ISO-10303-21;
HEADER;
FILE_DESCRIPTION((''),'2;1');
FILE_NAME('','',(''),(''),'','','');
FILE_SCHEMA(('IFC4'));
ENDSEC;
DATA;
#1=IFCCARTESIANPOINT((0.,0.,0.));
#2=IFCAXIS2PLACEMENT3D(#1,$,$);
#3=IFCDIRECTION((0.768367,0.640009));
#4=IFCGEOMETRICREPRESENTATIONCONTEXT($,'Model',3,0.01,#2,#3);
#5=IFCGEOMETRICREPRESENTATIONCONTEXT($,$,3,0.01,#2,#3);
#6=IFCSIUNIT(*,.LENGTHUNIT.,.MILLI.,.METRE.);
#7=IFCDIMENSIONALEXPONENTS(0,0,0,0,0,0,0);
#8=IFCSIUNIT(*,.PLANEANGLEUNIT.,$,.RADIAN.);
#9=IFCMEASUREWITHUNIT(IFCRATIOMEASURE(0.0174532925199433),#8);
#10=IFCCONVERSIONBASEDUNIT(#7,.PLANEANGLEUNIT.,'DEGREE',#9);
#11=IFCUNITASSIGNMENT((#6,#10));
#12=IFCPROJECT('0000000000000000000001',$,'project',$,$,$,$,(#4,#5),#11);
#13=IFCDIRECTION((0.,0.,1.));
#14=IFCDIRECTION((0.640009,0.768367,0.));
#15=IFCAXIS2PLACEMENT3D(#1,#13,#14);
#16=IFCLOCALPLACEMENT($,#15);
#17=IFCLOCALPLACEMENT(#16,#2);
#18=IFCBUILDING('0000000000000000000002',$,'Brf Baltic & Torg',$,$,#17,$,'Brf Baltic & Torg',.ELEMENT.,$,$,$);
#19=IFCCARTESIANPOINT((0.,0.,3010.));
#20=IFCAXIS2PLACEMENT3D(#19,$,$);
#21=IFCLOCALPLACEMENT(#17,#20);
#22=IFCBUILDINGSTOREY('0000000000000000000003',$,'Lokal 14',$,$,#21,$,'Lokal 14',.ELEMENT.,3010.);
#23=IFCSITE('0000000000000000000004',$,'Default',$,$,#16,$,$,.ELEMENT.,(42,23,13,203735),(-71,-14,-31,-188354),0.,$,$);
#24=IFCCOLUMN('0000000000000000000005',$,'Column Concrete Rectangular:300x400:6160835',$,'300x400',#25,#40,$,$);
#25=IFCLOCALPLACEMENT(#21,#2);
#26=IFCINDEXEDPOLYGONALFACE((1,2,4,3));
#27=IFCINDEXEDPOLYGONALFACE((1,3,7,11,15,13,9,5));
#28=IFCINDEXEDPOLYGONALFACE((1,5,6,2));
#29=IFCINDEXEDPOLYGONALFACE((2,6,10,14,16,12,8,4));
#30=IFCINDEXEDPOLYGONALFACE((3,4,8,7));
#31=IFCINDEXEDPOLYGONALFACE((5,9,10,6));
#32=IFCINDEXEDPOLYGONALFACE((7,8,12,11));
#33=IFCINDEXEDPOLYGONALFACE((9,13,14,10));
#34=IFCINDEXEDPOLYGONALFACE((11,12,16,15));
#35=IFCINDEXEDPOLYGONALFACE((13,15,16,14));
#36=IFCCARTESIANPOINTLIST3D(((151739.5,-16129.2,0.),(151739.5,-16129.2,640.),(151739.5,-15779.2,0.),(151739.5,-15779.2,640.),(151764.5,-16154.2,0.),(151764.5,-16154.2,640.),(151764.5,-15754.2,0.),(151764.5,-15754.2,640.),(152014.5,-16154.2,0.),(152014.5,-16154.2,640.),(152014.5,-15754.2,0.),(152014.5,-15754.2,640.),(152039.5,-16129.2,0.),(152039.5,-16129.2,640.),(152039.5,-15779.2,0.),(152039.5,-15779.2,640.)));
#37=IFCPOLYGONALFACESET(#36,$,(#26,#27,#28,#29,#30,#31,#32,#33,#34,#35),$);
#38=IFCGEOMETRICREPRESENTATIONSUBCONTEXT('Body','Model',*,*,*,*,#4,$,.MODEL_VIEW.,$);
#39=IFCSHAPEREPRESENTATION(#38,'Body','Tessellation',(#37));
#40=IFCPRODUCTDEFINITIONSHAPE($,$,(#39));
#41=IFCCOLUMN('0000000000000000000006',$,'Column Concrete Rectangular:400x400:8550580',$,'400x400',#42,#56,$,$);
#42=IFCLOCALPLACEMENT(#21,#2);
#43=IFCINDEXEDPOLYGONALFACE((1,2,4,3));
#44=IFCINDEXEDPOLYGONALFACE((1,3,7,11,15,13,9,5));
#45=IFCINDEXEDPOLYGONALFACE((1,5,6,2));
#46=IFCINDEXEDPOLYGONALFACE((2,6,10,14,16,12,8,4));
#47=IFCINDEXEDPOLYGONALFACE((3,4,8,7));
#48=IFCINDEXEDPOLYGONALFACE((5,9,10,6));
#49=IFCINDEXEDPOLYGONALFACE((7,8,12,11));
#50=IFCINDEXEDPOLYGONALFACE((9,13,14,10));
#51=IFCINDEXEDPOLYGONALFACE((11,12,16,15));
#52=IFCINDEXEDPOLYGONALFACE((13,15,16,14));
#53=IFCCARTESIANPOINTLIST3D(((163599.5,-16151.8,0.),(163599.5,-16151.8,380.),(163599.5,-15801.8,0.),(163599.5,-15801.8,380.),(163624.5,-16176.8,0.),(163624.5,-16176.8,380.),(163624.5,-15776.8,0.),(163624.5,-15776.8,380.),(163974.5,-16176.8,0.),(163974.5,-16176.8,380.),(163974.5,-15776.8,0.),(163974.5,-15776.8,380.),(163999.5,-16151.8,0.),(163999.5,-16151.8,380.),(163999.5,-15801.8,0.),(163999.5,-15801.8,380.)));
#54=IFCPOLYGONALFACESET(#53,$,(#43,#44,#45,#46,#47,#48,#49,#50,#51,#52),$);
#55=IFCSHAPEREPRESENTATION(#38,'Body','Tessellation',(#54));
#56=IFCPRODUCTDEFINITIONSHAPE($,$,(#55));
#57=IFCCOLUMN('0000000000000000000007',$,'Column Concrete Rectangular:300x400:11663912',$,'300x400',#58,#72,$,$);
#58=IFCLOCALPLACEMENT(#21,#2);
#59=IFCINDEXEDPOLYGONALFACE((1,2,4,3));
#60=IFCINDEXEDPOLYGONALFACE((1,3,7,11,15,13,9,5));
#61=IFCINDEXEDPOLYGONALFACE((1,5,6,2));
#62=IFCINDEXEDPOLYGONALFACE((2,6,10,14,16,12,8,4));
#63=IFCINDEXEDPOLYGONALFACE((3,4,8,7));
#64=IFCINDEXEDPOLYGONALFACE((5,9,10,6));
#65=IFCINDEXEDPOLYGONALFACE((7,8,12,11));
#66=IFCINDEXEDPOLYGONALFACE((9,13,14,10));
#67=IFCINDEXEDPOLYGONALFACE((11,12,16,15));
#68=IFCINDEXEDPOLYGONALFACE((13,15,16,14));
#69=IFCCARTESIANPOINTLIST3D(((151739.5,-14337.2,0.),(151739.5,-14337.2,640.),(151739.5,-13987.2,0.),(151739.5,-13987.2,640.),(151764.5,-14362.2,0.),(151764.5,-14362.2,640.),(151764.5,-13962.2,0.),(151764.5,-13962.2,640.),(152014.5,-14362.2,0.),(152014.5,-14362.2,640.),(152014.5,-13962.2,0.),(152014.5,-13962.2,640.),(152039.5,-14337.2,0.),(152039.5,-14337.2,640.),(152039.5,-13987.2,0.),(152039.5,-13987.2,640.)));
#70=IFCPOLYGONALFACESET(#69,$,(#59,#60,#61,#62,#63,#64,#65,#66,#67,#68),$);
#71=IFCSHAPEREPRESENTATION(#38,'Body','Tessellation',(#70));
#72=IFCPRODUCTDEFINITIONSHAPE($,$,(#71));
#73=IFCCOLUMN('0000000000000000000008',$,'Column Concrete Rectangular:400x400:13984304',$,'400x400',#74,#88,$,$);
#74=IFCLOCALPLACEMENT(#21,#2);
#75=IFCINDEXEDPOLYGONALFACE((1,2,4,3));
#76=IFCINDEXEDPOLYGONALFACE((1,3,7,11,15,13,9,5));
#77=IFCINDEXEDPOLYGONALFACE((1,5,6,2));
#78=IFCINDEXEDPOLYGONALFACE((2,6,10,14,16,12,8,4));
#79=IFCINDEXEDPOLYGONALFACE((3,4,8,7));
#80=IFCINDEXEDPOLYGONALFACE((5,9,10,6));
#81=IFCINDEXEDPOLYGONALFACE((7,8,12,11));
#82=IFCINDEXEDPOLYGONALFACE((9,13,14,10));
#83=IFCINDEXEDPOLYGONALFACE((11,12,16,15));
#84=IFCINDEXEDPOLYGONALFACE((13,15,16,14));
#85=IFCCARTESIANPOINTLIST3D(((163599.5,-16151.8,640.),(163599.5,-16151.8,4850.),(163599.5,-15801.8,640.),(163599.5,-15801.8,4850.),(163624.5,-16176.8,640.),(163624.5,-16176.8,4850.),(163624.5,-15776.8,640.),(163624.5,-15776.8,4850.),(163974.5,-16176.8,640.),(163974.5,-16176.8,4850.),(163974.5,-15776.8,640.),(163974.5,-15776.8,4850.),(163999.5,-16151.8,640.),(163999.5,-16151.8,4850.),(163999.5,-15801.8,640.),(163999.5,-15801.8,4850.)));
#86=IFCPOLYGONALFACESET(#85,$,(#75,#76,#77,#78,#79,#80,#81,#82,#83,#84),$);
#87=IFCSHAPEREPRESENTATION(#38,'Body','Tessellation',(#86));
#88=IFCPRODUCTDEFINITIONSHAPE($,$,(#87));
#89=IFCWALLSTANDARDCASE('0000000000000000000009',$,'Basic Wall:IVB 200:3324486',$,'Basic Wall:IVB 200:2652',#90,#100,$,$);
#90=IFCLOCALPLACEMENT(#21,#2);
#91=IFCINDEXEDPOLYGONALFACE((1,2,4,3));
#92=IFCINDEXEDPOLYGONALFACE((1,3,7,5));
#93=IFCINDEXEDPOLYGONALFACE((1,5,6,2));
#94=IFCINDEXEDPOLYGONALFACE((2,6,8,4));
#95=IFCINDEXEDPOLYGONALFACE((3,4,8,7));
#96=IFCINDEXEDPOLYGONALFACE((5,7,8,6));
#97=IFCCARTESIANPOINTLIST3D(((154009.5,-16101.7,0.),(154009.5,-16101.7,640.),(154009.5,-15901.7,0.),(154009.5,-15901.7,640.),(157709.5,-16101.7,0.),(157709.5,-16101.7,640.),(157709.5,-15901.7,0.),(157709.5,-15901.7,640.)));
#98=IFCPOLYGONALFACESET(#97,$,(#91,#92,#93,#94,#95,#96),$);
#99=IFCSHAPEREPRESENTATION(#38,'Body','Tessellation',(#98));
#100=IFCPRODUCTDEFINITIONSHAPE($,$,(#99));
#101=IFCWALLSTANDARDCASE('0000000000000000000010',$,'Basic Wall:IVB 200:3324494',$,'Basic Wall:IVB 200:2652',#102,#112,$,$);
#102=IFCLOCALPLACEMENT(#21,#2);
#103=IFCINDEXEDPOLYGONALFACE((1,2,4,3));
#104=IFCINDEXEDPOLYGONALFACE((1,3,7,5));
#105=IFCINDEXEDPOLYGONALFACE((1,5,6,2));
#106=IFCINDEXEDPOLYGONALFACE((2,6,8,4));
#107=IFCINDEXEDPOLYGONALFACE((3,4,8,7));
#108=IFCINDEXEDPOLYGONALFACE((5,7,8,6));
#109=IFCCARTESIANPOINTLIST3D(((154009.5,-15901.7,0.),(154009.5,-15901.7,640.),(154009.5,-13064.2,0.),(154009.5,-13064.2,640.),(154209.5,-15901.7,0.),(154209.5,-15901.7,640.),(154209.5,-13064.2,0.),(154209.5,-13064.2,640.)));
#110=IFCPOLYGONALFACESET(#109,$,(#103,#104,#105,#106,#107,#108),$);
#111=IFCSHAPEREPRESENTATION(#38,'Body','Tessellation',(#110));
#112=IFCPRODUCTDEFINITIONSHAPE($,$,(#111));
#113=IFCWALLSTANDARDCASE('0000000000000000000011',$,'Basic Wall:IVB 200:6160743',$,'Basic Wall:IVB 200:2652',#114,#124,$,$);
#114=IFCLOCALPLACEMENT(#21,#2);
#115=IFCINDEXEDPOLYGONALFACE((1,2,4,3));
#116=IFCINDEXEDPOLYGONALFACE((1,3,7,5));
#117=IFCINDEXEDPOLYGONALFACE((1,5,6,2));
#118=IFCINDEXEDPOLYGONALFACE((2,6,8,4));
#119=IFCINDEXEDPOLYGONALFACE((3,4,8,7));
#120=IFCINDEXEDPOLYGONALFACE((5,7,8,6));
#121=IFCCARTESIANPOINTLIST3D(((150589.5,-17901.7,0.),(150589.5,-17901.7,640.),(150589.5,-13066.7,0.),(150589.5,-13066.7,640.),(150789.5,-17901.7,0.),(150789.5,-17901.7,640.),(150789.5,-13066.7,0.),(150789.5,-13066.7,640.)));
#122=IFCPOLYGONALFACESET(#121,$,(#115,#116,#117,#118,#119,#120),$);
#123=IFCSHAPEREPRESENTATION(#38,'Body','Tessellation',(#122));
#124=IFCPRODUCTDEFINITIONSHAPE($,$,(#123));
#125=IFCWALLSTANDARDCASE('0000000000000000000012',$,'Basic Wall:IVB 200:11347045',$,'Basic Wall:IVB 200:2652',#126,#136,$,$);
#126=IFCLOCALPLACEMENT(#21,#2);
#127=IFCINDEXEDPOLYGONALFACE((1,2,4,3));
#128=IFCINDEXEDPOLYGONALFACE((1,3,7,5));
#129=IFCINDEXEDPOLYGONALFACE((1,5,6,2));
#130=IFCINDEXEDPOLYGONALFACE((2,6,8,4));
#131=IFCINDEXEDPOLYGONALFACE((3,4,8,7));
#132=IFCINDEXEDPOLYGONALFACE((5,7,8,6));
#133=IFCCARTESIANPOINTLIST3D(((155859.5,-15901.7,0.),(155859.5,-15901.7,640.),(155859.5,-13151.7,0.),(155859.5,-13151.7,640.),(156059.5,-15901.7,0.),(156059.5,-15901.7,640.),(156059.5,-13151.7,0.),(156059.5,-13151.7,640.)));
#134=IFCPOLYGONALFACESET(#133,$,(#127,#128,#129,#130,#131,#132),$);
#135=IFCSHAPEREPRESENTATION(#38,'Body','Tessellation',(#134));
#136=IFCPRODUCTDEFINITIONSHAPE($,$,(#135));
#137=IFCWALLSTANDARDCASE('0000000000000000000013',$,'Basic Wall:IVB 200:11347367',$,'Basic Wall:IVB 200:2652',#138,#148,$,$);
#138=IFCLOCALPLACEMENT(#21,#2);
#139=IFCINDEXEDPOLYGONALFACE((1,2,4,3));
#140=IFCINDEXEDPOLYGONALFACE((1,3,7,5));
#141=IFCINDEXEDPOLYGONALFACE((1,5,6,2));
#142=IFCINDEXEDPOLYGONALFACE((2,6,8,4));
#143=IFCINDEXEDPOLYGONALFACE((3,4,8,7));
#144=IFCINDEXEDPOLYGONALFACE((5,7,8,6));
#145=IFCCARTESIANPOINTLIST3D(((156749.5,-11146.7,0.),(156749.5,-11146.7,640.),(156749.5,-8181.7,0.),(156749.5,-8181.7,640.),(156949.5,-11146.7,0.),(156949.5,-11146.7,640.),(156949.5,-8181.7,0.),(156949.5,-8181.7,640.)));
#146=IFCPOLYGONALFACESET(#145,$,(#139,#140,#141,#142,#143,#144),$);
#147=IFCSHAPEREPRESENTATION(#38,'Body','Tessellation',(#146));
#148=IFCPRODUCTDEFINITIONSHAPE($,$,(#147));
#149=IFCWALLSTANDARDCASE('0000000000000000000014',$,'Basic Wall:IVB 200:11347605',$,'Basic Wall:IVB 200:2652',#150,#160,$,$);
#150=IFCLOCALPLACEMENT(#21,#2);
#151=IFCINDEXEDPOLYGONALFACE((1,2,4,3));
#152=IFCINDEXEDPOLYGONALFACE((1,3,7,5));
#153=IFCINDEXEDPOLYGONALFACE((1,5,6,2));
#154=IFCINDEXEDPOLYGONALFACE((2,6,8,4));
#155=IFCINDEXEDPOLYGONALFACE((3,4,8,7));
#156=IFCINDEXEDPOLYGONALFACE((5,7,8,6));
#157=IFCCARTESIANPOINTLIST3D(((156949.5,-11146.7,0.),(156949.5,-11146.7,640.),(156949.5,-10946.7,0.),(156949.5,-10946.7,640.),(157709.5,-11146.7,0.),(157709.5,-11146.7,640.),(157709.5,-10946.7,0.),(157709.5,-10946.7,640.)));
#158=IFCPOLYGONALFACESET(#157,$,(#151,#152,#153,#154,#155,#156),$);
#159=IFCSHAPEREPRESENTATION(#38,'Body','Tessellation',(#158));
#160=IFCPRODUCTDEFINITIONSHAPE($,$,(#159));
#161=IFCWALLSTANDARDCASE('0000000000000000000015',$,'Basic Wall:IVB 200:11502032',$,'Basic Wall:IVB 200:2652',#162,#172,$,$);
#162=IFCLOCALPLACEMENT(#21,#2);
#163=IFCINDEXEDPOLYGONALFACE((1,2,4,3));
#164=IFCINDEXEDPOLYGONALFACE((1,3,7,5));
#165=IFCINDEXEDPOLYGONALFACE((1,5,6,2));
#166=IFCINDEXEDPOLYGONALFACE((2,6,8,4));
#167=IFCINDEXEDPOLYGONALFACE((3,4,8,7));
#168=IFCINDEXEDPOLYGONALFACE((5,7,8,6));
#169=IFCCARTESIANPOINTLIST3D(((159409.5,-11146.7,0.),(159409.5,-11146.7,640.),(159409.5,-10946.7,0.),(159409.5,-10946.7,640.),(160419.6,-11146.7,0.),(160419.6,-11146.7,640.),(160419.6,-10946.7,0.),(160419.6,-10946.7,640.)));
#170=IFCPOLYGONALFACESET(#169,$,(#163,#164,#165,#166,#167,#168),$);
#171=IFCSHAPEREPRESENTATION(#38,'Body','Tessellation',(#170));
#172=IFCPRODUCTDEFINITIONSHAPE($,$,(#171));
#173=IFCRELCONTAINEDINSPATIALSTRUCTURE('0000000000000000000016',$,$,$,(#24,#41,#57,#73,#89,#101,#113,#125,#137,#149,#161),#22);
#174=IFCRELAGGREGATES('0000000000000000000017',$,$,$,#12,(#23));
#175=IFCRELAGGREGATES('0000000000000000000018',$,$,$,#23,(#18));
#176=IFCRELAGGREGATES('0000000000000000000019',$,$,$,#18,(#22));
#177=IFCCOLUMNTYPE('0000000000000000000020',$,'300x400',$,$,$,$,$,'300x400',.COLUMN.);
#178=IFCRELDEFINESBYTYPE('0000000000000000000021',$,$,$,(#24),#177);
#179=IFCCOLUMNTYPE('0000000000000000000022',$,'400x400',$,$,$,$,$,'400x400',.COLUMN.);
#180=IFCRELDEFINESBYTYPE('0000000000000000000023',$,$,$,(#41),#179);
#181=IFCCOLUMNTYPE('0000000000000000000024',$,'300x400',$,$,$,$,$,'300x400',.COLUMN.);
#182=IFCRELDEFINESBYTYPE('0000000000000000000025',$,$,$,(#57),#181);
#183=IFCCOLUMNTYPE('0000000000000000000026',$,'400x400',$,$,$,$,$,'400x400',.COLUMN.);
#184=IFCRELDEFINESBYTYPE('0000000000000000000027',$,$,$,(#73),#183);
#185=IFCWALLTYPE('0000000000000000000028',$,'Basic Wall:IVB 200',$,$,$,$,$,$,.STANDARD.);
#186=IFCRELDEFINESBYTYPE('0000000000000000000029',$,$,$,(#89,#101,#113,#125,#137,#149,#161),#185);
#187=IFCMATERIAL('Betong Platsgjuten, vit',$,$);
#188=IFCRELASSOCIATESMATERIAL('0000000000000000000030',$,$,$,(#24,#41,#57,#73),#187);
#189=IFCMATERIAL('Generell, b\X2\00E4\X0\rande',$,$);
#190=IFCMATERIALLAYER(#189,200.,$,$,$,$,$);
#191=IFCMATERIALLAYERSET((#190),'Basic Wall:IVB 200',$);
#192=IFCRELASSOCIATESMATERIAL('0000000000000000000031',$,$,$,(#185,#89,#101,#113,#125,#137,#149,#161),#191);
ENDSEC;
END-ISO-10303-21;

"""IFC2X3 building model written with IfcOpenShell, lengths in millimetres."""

from ifc_helpers import new_model, entity, si_unit, converted_unit, direction, frame, frame_2d, origin, place, context, subcontext, project, spatial, polyline, rectangle, outline, extrude, clip, halfspace, source, transform, mapped, material, layer, layer_set, layer_usage, type_object, type_shapes, element, save


model = new_model("IFC2X3")

# Units and contexts
model_context = context("Model", 3, precision=0.01, world=origin(), true_north=direction((0.768367, 0.640009)))
context_of_model = context(None, 3, precision=0.01, world=origin(), true_north=direction((0.768367, 0.640009)))
body_context = subcontext(model_context, "Body", "Model", "MODEL_VIEW")
ifc_project = project(units=[si_unit("LENGTHUNIT", "METRE", prefix="MILLI"), converted_unit("PLANEANGLEUNIT", "DEGREE", entity("IfcRatioMeasure", 0.0174532925199433), si_unit("PLANEANGLEUNIT", "RADIAN"), dimensions=[0, 0, 0, 0, 0, 0, 0])], contexts=[model_context, context_of_model])

# Site, building, storey
site_placement = place(None, frame((0.0, 0.0, 0.0), z_axis=(0.0, 0.0, 1.0), x_axis=(0.640009, 0.768367, 0.0)))
site = spatial("IfcSite", under=ifc_project, at=site_placement, Name="Default", CompositionType="ELEMENT", RefLatitude=(42, 23, 13, 203735), RefLongitude=(-71, -14, -31, -188354), RefElevation=0.0)
building_placement = place(site_placement, origin())
building = spatial("IfcBuilding", under=site, at=building_placement, Name="Brf Baltic & Torg", LongName="Brf Baltic & Torg", CompositionType="ELEMENT")
storey_placement = place(building_placement, frame((0.0, 0.0, 3010.0)))
storey = spatial("IfcBuildingStorey", under=building, at=storey_placement, Name="Lokal 14", LongName="Lokal 14", CompositionType="ELEMENT", Elevation=3010.0)

# Columns
ifc_material_1 = material(Name="Betong Platsgjuten, vit")
column_type_1 = type_object("IfcColumnType", Name="300x400", ElementType="300x400", PredefinedType="COLUMN")
shared_shape_1 = source(origin(), body_context, "Body", "SweptSolid", [
    extrude(outline(polyline([(-175.0, -150.0), (175.0, -150.0), (200.0, -125.0), (200.0, 125.0), (175.0, 150.0), (-175.0, 150.0), (-200.0, 125.0), (-200.0, -125.0), (-175.0, -150.0)])), frame((0.0, 0.0, 3010.0), z_axis=(0.0, 0.0, 1.0), x_axis=(0.0, -1.0, 0.0)), (0.0, 0.0, 1.0), 640.0),
])
type_shapes(column_type_1, [shared_shape_1])
column_1_placement = place(storey_placement, frame((151889.5, -15954.2, -3010.0)))
element("IfcColumn", 1, at=column_1_placement, inside=storey, type_object=column_type_1, material=ifc_material_1, Name="Column Concrete Rectangular:300x400:6160835", ObjectType="300x400", context=body_context, shape_type="MappedRepresentation", body=[
    mapped(shared_shape_1, transform((0.0, 0.0, 0.0), scale=1.0)),
])
column_type_2 = type_object("IfcColumnType", Name="400x400", ElementType="400x400", PredefinedType="COLUMN")
shared_shape_2 = source(origin(), body_context, "Body", "SweptSolid", [
    extrude(outline(polyline([(-175.0, -200.0), (175.0, -200.0), (200.0, -175.0), (200.0, 175.0), (175.0, 200.0), (-175.0, 200.0), (-200.0, 175.0), (-200.0, -175.0), (-175.0, -200.0)])), frame((0.0, 0.0, 3010.0), z_axis=(0.0, 0.0, 1.0), x_axis=(0.0, -1.0, 0.0)), (0.0, 0.0, 1.0), 380.0),
])
type_shapes(column_type_2, [shared_shape_2])
column_2_placement = place(storey_placement, frame((163799.5, -15976.8, -3010.0)))
element("IfcColumn", 2, at=column_2_placement, inside=storey, type_object=column_type_2, material=ifc_material_1, Name="Column Concrete Rectangular:400x400:8550580", ObjectType="400x400", context=body_context, shape_type="MappedRepresentation", body=[
    mapped(shared_shape_2, transform((0.0, 0.0, 0.0), scale=1.0)),
])
column_type_3 = type_object("IfcColumnType", Name="300x400", ElementType="300x400", PredefinedType="COLUMN")
shared_shape_3 = source(origin(), body_context, "Body", "SweptSolid", [
    extrude(outline(polyline([(-175.0, -150.0), (175.0, -150.0), (200.0, -125.0), (200.0, 125.0), (175.0, 150.0), (-175.0, 150.0), (-200.0, 125.0), (-200.0, -125.0), (-175.0, -150.0)])), frame((0.0, 0.0, 3010.0), z_axis=(0.0, 0.0, 1.0), x_axis=(0.0, -1.0, 0.0)), (0.0, 0.0, 1.0), 640.0),
])
type_shapes(column_type_3, [shared_shape_3])
column_3_placement = place(storey_placement, frame((151889.5, -14162.2, -3010.0)))
element("IfcColumn", 3, at=column_3_placement, inside=storey, type_object=column_type_3, material=ifc_material_1, Name="Column Concrete Rectangular:300x400:11663912", ObjectType="300x400", context=body_context, shape_type="MappedRepresentation", body=[
    mapped(shared_shape_3, transform((0.0, 0.0, 0.0), scale=1.0)),
])
column_type_4 = type_object("IfcColumnType", Name="400x400", ElementType="400x400", PredefinedType="COLUMN")
shared_shape_4 = source(origin(), body_context, "Body", "SweptSolid", [
    extrude(outline(polyline([(-175.0, -200.0), (175.0, -200.0), (200.0, -175.0), (200.0, 175.0), (175.0, 200.0), (-175.0, 200.0), (-200.0, 175.0), (-200.0, -175.0), (-175.0, -200.0)])), frame((0.0, 0.0, 3650.0), z_axis=(0.0, 0.0, 1.0), x_axis=(0.0, -1.0, 0.0)), (0.0, 0.0, 1.0), 4210.0),
])
type_shapes(column_type_4, [shared_shape_4])
column_4_placement = place(storey_placement, frame((163799.5, -15976.8, -3010.0)))
element("IfcColumn", 4, at=column_4_placement, inside=storey, type_object=column_type_4, material=ifc_material_1, Name="Column Concrete Rectangular:400x400:13984304", ObjectType="400x400", context=body_context, shape_type="MappedRepresentation", body=[
    mapped(shared_shape_4, transform((0.0, 0.0, 0.0), scale=1.0)),
])

# Walls
ifc_material_2 = material(Name="Generell, bärande")
ifc_layer = layer(ifc_material_2, 200.0)
ifc_layer_set = layer_set([ifc_layer], Name="Basic Wall:IVB 200")
ifc_layer_usage_1 = layer_usage(ifc_layer_set, "AXIS2", "NEGATIVE", 100.0)
wall_type = type_object("IfcWallType", Name="Basic Wall:IVB 200", PredefinedType="STANDARD", material=ifc_layer_set)
wall_1_placement = place(storey_placement, frame((157709.5, -16001.7, 0.0), z_axis=(0.0, 0.0, 1.0), x_axis=(-1.0, 0.0, 0.0)))
element("IfcWallStandardCase", 5, at=wall_1_placement, inside=storey, type_object=wall_type, material=ifc_layer_usage_1, Name="Basic Wall:IVB 200:3324486", ObjectType="Basic Wall:IVB 200:2652", context=body_context, shape_type="Clipping", body=[
    clip(extrude(rectangle(XDim=3700.0, YDim=200.0, at=frame_2d((1850.0, 0.0), x_axis=(-1.0, 0.0))), origin(), (0.0, 0.0, 1.0), 640.0), halfspace(frame((0.0, 0.0, -1360.0)), True)),
])
ifc_layer_usage_2 = layer_usage(ifc_layer_set, "AXIS2", "NEGATIVE", 100.0)
wall_2_placement = place(storey_placement, frame((154109.5, -15901.7, 0.0), z_axis=(0.0, 0.0, 1.0), x_axis=(0.0, 1.0, 0.0)))
element("IfcWallStandardCase", 6, at=wall_2_placement, inside=storey, type_object=wall_type, material=ifc_layer_usage_2, Name="Basic Wall:IVB 200:3324494", ObjectType="Basic Wall:IVB 200:2652", context=body_context, shape_type="Clipping", body=[
    clip(extrude(rectangle(XDim=2837.5, YDim=200.0, at=frame_2d((1418.7, 0.0), x_axis=(-1.0, 0.0))), origin(), (0.0, 0.0, 1.0), 640.0), halfspace(frame((0.0, 0.0, -1360.0)), True)),
])

# Walls
ifc_layer_usage_3 = layer_usage(ifc_layer_set, "AXIS2", "POSITIVE", -100.0)
wall_3_placement = place(storey_placement, frame((150689.5, -13066.7, 0.0), z_axis=(0.0, 0.0, 1.0), x_axis=(0.0, -1.0, 0.0)))
element("IfcWallStandardCase", 7, at=wall_3_placement, inside=storey, type_object=wall_type, material=ifc_layer_usage_3, Name="Basic Wall:IVB 200:6160743", ObjectType="Basic Wall:IVB 200:2652", context=body_context, shape_type="Clipping", body=[
    clip(extrude(rectangle(XDim=4835.0, YDim=200.0, at=frame_2d((2417.5, 0.0), x_axis=(-1.0, 0.0))), origin(), (0.0, 0.0, 1.0), 640.0), halfspace(frame((0.0, 0.0, -1360.0)), True)),
])
ifc_layer_usage_4 = layer_usage(ifc_layer_set, "AXIS2", "NEGATIVE", 100.0)
wall_4_placement = place(storey_placement, frame((155959.5, -15901.7, 0.0), z_axis=(0.0, 0.0, 1.0), x_axis=(0.0, 1.0, 0.0)))
element("IfcWallStandardCase", 8, at=wall_4_placement, inside=storey, type_object=wall_type, material=ifc_layer_usage_4, Name="Basic Wall:IVB 200:11347045", ObjectType="Basic Wall:IVB 200:2652", context=body_context, shape_type="Clipping", body=[
    clip(extrude(rectangle(XDim=2750.0, YDim=200.0, at=frame_2d((1375.0, 0.0), x_axis=(-1.0, 0.0))), origin(), (0.0, 0.0, 1.0), 640.0), halfspace(frame((0.0, 0.0, -1360.0)), True)),
])
ifc_layer_usage_5 = layer_usage(ifc_layer_set, "AXIS2", "POSITIVE", -100.0)
wall_5_placement = place(storey_placement, frame((156849.5, -8181.7, 0.0), z_axis=(0.0, 0.0, 1.0), x_axis=(0.0, -1.0, 0.0)))
element("IfcWallStandardCase", 9, at=wall_5_placement, inside=storey, type_object=wall_type, material=ifc_layer_usage_5, Name="Basic Wall:IVB 200:11347367", ObjectType="Basic Wall:IVB 200:2652", context=body_context, shape_type="Clipping", body=[
    clip(extrude(rectangle(XDim=2965.0, YDim=200.0, at=frame_2d((1482.5, 0.0), x_axis=(-1.0, 0.0))), origin(), (0.0, 0.0, 1.0), 640.0), halfspace(frame((0.0, 0.0, -1360.0)), True)),
])
ifc_layer_usage_6 = layer_usage(ifc_layer_set, "AXIS2", "NEGATIVE", 100.0)
wall_6_placement = place(storey_placement, frame((156949.5, -11046.7, 0.0)))
element("IfcWallStandardCase", 10, at=wall_6_placement, inside=storey, type_object=wall_type, material=ifc_layer_usage_6, Name="Basic Wall:IVB 200:11347605", ObjectType="Basic Wall:IVB 200:2652", context=body_context, shape_type="Clipping", body=[
    clip(extrude(rectangle(XDim=760.0, YDim=200.0, at=frame_2d((380.0, 0.0), x_axis=(-1.0, 0.0))), origin(), (0.0, 0.0, 1.0), 640.0), halfspace(frame((0.0, 0.0, -1360.0)), True)),
])
ifc_layer_usage_7 = layer_usage(ifc_layer_set, "AXIS2", "NEGATIVE", 100.0)
wall_7_placement = place(storey_placement, frame((159409.5, -11046.7, 0.0)))
element("IfcWallStandardCase", 11, at=wall_7_placement, inside=storey, type_object=wall_type, material=ifc_layer_usage_7, Name="Basic Wall:IVB 200:11502032", ObjectType="Basic Wall:IVB 200:2652", context=body_context, shape_type="Clipping", body=[
    clip(extrude(rectangle(XDim=1010.1, YDim=200.0, at=frame_2d((505.0, 0.0), x_axis=(-1.0, 0.0))), origin(), (0.0, 0.0, 1.0), 640.0), halfspace(frame((0.0, 0.0, -1360.0)), True)),
])

save(model, "model.ifc")
